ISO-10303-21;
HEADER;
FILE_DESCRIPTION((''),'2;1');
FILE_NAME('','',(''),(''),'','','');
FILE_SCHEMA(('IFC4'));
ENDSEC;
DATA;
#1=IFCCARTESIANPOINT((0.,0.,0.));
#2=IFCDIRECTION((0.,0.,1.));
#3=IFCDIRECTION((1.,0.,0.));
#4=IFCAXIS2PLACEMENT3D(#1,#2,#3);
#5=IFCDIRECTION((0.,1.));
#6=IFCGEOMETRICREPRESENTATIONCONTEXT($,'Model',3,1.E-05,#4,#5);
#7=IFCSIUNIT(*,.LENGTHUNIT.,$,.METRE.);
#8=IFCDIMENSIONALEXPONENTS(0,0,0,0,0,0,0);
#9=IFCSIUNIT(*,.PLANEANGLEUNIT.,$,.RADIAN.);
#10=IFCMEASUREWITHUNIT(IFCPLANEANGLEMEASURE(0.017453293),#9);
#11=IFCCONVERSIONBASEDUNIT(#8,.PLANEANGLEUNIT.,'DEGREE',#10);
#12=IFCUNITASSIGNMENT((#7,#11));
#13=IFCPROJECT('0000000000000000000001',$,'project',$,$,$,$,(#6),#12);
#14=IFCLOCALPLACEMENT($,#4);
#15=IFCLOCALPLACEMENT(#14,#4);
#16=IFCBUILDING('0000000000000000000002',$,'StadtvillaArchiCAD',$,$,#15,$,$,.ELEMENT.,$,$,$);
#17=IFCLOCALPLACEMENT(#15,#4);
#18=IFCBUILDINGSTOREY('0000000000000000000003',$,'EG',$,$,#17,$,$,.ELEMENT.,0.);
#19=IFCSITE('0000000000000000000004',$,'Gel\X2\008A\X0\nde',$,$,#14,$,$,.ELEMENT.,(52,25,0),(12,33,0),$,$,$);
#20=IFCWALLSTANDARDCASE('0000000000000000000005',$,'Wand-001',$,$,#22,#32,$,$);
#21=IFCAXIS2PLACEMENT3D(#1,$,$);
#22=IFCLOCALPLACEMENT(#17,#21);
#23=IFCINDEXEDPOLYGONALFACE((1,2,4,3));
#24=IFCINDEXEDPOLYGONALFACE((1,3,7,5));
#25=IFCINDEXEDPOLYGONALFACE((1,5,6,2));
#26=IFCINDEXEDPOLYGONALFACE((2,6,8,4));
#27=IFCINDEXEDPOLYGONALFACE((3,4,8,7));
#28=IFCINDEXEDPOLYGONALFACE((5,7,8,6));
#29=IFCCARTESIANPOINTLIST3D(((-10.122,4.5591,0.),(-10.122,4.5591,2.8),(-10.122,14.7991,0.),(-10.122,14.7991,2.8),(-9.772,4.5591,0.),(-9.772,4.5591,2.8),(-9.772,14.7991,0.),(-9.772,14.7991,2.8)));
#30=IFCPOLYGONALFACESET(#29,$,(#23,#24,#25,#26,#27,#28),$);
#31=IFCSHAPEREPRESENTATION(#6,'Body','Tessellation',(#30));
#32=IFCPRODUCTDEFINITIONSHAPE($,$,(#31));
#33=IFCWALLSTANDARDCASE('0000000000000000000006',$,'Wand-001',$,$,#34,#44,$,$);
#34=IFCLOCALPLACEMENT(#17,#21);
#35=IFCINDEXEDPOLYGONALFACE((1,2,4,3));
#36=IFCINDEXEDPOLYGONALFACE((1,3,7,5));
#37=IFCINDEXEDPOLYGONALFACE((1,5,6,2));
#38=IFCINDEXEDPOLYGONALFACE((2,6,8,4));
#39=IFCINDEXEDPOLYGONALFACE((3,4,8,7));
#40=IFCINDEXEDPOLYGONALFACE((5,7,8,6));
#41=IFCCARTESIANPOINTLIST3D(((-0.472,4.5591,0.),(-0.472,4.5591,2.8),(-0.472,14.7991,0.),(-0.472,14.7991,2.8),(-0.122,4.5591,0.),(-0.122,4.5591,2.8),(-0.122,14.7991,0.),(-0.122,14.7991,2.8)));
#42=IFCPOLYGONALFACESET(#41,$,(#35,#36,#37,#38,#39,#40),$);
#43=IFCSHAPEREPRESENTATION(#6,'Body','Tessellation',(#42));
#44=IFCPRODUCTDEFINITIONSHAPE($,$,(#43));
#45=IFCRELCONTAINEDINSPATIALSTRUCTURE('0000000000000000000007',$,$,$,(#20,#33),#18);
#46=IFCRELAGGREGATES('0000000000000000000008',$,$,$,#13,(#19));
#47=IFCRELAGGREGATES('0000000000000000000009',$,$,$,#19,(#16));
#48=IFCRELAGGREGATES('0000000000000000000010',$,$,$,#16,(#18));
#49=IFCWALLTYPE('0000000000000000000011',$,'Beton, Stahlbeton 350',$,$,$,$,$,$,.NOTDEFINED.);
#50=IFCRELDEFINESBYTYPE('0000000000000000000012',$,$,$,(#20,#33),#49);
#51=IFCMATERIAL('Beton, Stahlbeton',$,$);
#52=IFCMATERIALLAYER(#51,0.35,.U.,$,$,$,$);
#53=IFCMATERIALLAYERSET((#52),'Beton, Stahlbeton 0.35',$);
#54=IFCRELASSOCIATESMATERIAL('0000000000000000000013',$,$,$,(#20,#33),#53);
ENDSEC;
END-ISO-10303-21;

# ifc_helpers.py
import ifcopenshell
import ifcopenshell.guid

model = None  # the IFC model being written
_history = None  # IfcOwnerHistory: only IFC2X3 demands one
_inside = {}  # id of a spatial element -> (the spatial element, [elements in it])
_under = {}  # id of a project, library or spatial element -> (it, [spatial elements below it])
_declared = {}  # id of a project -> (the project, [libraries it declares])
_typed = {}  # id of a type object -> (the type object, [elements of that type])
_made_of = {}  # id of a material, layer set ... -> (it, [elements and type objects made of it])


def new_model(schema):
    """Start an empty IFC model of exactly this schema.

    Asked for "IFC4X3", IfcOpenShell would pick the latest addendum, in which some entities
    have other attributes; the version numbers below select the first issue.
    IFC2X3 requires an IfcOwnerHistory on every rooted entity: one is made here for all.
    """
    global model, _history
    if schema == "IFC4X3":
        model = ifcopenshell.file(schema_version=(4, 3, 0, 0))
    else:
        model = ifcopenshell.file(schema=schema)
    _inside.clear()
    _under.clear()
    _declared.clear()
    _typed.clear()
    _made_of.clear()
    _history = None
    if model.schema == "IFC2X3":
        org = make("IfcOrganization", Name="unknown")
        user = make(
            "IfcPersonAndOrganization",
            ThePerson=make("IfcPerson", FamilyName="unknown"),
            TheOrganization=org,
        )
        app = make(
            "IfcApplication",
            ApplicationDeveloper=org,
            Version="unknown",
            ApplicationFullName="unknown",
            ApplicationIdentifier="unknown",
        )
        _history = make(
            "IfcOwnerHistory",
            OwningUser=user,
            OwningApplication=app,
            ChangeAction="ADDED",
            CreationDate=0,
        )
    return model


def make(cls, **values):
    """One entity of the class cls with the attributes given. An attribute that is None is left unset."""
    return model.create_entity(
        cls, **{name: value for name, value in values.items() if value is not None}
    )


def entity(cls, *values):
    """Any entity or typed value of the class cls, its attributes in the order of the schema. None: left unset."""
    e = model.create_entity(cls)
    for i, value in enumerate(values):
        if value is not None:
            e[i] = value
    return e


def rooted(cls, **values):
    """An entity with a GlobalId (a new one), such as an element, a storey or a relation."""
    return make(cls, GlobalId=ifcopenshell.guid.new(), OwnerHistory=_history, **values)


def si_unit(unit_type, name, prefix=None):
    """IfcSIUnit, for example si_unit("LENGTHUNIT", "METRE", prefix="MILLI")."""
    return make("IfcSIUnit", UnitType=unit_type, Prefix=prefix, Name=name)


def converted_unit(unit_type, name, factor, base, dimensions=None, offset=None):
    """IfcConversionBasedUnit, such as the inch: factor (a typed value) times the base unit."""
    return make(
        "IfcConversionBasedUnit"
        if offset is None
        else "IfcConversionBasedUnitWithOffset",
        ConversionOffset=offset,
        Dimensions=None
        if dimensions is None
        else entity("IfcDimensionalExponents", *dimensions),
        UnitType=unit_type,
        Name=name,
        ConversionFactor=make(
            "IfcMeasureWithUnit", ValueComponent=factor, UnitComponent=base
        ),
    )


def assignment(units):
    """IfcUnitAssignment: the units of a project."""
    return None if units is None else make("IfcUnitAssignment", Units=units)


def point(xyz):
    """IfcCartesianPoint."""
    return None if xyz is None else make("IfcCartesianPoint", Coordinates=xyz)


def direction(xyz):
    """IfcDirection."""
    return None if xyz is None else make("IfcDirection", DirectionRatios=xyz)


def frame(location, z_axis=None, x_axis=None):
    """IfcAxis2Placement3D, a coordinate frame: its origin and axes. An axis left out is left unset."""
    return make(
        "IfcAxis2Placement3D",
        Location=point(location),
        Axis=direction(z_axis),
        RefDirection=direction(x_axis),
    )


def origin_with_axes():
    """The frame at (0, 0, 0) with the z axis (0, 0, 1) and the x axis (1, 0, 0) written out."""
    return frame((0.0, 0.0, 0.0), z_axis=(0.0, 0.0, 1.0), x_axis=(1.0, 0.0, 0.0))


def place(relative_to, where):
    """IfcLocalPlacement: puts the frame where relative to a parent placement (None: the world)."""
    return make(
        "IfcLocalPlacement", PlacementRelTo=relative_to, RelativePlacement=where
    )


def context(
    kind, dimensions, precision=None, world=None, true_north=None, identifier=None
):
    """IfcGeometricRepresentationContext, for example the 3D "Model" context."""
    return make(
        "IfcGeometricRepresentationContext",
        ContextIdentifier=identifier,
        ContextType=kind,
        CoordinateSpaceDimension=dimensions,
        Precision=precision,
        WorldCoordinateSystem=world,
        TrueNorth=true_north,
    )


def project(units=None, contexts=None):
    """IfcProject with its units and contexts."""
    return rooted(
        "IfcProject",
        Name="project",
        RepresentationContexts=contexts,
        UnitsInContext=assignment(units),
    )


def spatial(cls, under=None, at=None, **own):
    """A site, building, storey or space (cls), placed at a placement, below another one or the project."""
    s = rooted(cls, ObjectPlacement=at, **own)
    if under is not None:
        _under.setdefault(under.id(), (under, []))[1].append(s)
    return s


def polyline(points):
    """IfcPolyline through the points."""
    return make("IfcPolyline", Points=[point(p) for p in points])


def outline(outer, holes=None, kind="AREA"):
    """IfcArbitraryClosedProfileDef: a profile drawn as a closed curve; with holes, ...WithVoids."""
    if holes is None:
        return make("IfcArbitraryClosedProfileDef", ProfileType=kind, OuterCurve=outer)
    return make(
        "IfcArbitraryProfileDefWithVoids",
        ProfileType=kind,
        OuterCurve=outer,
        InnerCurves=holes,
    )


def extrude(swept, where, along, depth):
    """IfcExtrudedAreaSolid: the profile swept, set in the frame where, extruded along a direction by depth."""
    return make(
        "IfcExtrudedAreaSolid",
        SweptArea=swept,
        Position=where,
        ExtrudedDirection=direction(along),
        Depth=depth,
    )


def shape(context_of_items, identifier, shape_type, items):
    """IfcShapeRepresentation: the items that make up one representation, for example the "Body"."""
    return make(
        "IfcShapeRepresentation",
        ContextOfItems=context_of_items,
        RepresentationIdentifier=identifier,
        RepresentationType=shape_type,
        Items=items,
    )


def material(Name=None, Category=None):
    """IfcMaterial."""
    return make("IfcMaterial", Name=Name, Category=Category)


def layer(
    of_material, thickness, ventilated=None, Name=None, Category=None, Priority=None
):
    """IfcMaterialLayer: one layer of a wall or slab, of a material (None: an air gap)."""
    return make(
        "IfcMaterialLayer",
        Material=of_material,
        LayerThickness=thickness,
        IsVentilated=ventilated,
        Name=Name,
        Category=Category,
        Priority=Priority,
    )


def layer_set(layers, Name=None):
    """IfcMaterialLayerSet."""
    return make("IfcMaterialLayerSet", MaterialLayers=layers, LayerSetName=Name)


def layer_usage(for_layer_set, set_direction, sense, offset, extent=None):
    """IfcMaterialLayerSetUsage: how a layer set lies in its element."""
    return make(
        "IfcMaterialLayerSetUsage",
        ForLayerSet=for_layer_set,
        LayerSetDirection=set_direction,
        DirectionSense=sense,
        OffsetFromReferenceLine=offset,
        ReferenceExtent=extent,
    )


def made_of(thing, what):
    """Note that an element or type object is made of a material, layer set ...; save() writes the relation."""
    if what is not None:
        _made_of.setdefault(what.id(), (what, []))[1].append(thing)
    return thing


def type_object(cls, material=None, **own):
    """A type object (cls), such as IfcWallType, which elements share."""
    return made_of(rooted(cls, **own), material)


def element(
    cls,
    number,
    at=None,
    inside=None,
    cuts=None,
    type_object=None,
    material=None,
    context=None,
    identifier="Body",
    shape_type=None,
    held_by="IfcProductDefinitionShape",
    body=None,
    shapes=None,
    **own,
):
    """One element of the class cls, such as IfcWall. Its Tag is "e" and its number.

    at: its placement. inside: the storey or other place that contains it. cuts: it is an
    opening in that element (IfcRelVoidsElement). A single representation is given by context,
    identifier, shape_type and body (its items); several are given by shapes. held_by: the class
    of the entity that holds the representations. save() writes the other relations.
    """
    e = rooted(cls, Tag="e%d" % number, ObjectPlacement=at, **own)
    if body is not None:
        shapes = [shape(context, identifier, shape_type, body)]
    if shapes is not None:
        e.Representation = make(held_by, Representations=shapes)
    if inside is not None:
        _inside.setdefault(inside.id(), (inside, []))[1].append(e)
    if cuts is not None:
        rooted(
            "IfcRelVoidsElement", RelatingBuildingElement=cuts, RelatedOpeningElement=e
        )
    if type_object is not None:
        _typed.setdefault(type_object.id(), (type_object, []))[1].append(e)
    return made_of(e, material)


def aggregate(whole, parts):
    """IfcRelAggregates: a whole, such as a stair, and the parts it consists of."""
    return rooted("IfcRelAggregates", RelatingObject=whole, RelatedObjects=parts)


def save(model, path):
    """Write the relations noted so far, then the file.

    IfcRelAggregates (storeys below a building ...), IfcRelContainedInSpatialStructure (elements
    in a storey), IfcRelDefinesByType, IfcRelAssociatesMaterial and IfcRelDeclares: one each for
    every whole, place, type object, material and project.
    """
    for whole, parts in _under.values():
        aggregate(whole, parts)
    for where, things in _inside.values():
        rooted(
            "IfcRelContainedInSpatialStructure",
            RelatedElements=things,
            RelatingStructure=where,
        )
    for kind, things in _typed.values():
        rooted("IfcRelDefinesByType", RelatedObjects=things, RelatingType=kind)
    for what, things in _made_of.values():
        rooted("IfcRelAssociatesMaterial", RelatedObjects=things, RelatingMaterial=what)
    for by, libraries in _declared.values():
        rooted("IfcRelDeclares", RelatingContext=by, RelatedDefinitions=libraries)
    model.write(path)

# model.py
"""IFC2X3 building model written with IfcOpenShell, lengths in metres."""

from ifc_helpers import new_model, entity, si_unit, converted_unit, direction, frame, origin_with_axes, place, context, project, spatial, polyline, outline, extrude, material, layer, layer_set, layer_usage, type_object, element, save


model = new_model("IFC2X3")

# Units and contexts
model_context = context("Model", 3, precision=1e-05, world=origin_with_axes(), true_north=direction((0.0, 1.0)))
ifc_project = project(units=[si_unit("LENGTHUNIT", "METRE"), converted_unit("PLANEANGLEUNIT", "DEGREE", entity("IfcPlaneAngleMeasure", 0.017453293), si_unit("PLANEANGLEUNIT", "RADIAN"), dimensions=[0, 0, 0, 0, 0, 0, 0])], contexts=[model_context])

# Site, building, storey
site_placement = place(None, origin_with_axes())
site = spatial("IfcSite", under=ifc_project, at=site_placement, Name="Gel\u008ande", CompositionType="ELEMENT", RefLatitude=(52, 25, 0), RefLongitude=(12, 33, 0))
building_placement = place(site_placement, origin_with_axes())
building = spatial("IfcBuilding", under=site, at=building_placement, Name="StadtvillaArchiCAD", CompositionType="ELEMENT")
storey_placement = place(building_placement, origin_with_axes())
storey = spatial("IfcBuildingStorey", under=building, at=storey_placement, Name="EG", CompositionType="ELEMENT", Elevation=0.0)

# Shared definitions
ifc_material_1 = material(Name="Beton, Stahlbeton")

# Walls
ifc_layer_1 = layer(ifc_material_1, 0.35, ventilated="UNKNOWN")
ifc_layer_set_1 = layer_set([ifc_layer_1], Name="Beton, Stahlbeton 0.35")
ifc_layer_usage_1 = layer_usage(ifc_layer_set_1, "AXIS2", "NEGATIVE", 0.0)
wall_type_1 = type_object("IfcWallType", Name="Beton, Stahlbeton 350", PredefinedType="NOTDEFINED")
wall_1_placement = place(storey_placement, frame((-9.772, 14.7991, 0.0), z_axis=(0.0, 0.0, 1.0), x_axis=(0.0, -1.0, 0.0)))
element("IfcWallStandardCase", 1, at=wall_1_placement, inside=storey, type_object=wall_type_1, material=ifc_layer_usage_1, Name="Wand-001", context=model_context, shape_type="SweptSolid", body=[
    extrude(outline(polyline([(0.0, -0.35), (10.24, -0.35), (10.24, 0.0), (0.0, 0.0), (0.0, -0.35)])), origin_with_axes(), (0.0, 0.0, 1.0), 2.8),
])
ifc_layer_usage_2 = layer_usage(ifc_layer_set_1, "AXIS2", "NEGATIVE", 0.0)
wall_2_placement = place(storey_placement, frame((-0.122, 14.7991, 0.0), z_axis=(0.0, 0.0, 1.0), x_axis=(0.0, -1.0, 0.0)))
element("IfcWallStandardCase", 2, at=wall_2_placement, inside=storey, type_object=wall_type_1, material=ifc_layer_usage_2, Name="Wand-001", context=model_context, shape_type="SweptSolid", body=[
    extrude(outline(polyline([(0.0, -0.35), (10.24, -0.35), (10.24, 0.0), (0.0, 0.0), (0.0, -0.35)])), origin_with_axes(), (0.0, 0.0, 1.0), 2.8),
])

save(model, "model.ifc")
